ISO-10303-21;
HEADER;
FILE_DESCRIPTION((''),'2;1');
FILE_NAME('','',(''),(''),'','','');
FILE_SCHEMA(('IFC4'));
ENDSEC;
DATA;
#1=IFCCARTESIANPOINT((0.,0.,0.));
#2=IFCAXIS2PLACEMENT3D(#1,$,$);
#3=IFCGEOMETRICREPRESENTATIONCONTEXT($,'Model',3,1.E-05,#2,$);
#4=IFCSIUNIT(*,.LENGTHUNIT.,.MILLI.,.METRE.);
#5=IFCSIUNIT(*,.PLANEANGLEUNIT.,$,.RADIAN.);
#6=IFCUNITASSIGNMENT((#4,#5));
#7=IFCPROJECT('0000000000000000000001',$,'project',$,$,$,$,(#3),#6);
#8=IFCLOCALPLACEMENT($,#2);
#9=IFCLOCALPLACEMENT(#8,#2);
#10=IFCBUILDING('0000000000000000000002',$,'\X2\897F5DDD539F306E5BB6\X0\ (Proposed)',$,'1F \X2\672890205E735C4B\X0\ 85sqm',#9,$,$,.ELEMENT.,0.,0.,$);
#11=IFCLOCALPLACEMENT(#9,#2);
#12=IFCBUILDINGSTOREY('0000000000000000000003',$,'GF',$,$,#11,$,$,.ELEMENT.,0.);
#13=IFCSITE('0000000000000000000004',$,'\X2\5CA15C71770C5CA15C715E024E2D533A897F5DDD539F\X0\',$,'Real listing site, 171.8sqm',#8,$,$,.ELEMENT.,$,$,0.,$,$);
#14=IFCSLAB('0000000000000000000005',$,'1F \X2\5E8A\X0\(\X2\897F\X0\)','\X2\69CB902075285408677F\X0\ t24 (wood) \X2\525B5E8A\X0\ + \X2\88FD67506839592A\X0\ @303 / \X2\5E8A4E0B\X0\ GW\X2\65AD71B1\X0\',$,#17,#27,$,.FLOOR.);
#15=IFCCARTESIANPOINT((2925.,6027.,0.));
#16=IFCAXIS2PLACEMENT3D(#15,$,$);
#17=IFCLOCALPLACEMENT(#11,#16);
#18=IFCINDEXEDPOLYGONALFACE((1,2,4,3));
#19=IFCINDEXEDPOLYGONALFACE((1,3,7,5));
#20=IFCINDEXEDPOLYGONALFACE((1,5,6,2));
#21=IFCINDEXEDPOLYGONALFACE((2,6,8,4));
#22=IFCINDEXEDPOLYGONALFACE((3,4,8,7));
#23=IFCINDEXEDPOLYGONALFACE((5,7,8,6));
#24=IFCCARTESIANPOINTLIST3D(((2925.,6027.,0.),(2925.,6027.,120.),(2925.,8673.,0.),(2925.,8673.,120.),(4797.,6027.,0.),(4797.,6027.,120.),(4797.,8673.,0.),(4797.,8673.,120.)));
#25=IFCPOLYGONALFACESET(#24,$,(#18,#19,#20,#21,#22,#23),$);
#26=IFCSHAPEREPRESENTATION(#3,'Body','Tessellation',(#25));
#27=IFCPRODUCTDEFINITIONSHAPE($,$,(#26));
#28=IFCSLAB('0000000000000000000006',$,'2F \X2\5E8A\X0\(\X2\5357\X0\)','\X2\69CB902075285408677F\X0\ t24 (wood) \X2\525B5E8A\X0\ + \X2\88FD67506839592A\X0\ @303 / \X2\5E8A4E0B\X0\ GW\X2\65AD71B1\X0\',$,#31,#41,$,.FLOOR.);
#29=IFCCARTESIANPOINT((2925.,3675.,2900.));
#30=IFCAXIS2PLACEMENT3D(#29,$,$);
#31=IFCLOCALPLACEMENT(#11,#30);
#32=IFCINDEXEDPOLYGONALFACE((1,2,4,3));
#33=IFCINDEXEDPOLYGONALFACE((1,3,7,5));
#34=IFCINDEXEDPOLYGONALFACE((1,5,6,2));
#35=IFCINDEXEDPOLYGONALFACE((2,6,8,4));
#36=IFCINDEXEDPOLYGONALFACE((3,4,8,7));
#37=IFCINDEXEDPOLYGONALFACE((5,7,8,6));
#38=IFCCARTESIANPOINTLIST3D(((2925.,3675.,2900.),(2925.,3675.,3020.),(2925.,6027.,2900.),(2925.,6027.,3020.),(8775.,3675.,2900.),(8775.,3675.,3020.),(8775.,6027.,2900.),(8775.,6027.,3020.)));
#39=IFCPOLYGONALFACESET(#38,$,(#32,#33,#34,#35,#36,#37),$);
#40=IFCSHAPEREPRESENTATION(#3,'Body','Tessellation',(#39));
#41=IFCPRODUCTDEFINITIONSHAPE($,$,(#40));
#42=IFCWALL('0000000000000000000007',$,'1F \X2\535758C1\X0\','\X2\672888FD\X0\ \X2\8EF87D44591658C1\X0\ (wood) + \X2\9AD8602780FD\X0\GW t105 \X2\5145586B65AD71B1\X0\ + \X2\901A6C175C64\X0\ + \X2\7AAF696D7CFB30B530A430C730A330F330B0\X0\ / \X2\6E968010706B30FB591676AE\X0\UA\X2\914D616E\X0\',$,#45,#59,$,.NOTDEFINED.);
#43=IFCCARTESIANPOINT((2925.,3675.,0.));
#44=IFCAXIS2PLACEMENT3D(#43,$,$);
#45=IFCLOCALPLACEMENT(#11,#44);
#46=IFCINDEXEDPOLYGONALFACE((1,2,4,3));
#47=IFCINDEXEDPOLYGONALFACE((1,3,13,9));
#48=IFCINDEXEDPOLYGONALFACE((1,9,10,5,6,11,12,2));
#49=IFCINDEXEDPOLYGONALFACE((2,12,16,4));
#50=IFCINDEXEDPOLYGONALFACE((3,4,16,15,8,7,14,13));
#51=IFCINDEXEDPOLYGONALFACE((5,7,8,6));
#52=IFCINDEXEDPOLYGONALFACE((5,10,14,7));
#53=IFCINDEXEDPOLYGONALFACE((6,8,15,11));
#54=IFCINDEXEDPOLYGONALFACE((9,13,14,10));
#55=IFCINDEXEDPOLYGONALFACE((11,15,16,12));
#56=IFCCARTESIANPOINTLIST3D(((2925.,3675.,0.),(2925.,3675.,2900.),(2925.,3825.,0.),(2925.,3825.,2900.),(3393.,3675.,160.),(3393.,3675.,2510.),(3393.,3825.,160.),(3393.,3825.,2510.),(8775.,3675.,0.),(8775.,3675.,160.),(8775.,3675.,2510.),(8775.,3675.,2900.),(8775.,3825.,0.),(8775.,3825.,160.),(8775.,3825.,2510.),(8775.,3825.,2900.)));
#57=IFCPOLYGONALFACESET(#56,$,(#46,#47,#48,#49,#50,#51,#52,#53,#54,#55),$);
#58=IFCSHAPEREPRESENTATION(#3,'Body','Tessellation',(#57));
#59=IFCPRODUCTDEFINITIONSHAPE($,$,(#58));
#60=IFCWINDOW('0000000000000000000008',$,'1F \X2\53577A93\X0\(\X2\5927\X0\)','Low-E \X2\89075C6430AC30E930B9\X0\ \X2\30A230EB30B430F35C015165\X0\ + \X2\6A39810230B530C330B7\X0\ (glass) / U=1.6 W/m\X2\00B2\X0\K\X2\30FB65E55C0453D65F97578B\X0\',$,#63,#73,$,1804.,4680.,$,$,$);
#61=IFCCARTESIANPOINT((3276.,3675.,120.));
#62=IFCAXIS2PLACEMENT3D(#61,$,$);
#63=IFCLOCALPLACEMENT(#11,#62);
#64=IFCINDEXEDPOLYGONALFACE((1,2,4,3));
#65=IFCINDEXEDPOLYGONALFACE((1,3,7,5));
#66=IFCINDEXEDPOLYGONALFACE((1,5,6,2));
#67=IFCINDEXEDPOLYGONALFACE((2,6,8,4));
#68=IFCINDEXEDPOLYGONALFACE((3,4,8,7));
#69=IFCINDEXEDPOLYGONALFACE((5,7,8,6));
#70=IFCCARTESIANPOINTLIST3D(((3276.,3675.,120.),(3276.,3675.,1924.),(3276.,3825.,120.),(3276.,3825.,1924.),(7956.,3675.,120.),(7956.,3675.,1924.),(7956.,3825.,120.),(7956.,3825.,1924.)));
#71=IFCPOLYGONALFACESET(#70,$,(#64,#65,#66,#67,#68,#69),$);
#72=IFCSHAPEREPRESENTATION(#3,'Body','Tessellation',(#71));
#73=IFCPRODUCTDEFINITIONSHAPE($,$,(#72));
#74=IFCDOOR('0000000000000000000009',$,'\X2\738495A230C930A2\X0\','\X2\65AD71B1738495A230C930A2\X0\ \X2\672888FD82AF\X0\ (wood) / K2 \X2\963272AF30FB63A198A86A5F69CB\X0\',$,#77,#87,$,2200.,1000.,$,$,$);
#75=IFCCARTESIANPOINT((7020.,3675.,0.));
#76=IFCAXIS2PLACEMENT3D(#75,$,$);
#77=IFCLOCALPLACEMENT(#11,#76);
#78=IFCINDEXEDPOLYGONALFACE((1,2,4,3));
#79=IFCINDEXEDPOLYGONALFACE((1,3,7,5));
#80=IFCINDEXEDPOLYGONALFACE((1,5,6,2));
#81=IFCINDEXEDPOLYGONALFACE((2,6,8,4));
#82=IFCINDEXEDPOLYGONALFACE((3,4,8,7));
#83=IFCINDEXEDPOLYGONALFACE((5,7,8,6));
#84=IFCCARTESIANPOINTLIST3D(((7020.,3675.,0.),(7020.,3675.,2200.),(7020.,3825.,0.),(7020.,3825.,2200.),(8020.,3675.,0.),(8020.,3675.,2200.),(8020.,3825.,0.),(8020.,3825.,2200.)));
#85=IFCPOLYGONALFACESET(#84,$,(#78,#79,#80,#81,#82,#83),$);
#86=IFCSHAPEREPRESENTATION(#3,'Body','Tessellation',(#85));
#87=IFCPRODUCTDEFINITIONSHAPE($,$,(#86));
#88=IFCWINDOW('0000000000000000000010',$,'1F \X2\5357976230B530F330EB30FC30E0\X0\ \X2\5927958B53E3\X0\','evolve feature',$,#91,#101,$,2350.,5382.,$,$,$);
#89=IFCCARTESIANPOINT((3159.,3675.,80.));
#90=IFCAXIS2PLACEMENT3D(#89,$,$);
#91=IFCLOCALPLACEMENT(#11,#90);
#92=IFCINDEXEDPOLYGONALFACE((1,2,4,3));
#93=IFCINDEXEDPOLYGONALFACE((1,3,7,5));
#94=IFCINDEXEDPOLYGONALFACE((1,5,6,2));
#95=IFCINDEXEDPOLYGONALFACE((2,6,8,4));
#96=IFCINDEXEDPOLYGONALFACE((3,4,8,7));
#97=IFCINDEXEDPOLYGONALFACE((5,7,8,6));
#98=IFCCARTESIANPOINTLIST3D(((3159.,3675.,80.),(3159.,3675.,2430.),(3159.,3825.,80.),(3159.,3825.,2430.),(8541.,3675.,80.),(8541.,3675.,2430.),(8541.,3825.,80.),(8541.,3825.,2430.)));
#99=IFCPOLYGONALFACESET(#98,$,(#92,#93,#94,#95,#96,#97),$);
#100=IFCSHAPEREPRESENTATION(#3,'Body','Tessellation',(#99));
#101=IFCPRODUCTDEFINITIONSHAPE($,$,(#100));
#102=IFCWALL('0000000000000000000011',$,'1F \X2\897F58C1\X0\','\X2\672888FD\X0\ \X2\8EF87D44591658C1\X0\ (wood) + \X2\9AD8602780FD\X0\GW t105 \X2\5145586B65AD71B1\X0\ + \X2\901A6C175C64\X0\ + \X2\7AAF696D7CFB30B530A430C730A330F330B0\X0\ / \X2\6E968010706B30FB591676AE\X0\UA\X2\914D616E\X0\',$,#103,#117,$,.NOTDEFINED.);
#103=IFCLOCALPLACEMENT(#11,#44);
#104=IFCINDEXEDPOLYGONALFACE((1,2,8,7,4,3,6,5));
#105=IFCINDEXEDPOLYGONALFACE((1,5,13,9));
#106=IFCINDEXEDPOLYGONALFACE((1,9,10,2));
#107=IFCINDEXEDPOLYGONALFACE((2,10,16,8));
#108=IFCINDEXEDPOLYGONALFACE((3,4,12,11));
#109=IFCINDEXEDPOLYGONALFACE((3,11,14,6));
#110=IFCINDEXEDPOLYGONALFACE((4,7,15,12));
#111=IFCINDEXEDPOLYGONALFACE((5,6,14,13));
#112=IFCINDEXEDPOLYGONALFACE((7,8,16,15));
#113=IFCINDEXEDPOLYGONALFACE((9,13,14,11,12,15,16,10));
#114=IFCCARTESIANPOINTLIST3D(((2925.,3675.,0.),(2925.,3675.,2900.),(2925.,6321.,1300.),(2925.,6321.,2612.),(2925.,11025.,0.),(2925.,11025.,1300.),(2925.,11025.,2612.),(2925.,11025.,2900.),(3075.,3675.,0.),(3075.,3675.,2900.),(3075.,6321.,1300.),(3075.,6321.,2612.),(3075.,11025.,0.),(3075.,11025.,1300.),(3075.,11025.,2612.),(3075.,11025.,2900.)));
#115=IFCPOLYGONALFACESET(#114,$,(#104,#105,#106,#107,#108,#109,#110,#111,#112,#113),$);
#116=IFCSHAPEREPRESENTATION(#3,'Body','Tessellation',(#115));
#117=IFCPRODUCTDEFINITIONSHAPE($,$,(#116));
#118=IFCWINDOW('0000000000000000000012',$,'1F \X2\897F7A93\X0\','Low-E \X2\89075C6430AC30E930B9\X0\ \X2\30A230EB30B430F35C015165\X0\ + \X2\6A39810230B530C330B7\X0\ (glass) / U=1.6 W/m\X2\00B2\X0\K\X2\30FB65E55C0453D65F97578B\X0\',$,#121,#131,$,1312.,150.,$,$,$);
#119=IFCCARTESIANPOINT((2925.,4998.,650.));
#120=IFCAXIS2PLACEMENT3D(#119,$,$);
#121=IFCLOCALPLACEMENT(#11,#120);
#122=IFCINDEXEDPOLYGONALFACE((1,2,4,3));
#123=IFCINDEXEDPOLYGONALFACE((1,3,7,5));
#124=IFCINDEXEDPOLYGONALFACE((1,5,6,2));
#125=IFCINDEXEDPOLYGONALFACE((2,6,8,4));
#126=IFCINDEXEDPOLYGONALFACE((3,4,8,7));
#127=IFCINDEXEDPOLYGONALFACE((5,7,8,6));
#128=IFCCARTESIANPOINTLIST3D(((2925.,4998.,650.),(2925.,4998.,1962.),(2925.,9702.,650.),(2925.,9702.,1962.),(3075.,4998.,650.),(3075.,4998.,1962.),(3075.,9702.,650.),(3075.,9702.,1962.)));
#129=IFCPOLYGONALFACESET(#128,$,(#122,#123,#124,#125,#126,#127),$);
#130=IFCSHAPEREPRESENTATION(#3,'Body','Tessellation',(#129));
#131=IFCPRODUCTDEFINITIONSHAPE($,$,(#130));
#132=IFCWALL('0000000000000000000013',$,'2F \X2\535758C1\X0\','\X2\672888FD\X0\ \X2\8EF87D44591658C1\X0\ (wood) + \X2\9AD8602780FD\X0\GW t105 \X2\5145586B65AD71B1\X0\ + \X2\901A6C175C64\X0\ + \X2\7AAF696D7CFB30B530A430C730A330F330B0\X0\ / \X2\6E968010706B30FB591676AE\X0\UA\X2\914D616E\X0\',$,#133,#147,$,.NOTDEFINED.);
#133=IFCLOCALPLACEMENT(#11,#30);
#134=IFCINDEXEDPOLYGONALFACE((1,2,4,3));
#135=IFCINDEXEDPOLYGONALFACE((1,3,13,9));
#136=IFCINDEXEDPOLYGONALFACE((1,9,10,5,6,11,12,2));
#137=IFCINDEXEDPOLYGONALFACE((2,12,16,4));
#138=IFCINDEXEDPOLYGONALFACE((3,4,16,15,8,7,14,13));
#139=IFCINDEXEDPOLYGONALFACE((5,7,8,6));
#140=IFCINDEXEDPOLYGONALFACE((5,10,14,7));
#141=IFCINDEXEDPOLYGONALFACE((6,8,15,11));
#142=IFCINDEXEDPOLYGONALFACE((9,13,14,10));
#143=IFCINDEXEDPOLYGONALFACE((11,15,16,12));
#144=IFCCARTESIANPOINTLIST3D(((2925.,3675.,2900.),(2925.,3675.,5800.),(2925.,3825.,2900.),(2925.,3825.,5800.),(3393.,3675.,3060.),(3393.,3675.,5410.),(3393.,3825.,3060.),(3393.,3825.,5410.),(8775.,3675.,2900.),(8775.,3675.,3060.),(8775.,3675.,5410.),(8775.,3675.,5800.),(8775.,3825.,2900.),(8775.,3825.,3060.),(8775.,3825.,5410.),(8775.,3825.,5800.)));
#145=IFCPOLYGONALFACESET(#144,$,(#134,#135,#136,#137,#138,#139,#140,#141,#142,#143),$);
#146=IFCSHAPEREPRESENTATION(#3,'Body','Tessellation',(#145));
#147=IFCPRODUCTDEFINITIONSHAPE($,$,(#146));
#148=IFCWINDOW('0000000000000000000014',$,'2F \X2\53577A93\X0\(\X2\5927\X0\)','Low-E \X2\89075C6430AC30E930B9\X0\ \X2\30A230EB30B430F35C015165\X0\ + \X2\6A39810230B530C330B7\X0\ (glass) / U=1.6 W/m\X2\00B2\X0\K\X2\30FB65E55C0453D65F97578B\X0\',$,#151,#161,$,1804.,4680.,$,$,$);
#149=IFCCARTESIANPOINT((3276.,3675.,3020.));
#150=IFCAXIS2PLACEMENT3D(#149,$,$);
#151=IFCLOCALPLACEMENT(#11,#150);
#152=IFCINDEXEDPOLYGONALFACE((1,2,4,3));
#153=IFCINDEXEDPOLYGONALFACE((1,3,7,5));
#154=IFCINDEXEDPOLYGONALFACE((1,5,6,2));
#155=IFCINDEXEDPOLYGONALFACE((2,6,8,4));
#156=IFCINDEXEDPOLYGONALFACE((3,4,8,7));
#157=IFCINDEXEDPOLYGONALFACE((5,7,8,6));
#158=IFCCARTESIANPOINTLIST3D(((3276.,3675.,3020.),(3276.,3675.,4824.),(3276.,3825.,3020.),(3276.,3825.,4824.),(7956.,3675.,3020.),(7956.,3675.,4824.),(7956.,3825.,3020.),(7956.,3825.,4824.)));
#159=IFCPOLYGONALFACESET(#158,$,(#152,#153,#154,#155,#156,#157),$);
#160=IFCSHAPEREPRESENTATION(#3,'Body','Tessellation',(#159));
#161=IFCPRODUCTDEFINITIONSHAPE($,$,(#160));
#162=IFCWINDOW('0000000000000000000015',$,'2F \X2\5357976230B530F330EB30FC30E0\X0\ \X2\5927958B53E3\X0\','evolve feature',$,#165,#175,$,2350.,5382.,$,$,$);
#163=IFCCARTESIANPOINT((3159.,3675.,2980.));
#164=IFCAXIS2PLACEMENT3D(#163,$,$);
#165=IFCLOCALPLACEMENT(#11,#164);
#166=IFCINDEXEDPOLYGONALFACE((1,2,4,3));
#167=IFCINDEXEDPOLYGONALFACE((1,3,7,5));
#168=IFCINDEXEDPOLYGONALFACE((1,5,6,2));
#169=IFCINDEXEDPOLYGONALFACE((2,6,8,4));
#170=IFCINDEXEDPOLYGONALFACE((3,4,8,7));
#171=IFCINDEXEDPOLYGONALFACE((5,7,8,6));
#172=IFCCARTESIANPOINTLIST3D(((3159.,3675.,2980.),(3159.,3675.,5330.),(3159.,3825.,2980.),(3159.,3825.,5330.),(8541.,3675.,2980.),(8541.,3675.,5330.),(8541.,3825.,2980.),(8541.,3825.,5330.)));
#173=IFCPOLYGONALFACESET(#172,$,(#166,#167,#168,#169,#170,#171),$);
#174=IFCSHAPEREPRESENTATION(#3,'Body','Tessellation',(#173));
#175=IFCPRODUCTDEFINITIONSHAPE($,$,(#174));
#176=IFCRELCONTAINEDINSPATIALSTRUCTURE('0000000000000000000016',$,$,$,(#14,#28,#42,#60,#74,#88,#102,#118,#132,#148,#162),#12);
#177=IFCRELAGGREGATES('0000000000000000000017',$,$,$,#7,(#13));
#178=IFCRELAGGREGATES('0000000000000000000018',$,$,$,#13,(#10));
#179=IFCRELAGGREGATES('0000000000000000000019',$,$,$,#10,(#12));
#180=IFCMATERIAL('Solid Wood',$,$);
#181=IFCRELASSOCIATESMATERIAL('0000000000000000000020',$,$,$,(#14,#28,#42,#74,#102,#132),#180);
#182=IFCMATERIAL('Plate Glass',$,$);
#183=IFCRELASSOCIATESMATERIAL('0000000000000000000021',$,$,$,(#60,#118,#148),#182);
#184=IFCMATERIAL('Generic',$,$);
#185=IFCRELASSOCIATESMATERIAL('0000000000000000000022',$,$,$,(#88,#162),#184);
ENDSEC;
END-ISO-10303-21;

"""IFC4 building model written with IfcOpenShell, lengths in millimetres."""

from ifc_helpers import new_model, si_unit, frame, frame_2d, origin, place, context, project, spatial, rectangle, extrude, material, element, fill, save


model = new_model("IFC4")

# Units and contexts
model_context = context("Model", 3, precision=1e-05, world=origin())
ifc_project = project(units=[si_unit("LENGTHUNIT", "METRE", prefix="MILLI"), si_unit("PLANEANGLEUNIT", "RADIAN")], contexts=[model_context])

# Site, building, storey
site_placement = place(None, origin())
site = spatial("IfcSite", under=ifc_project, at=site_placement, Name="岡山県岡山市中区西川原", ObjectType="Real listing site, 171.8sqm", CompositionType="ELEMENT", RefElevation=0.0)
building_placement = place(site_placement, origin())
building = spatial("IfcBuilding", under=site, at=building_placement, Name="西川原の家 (Proposed)", ObjectType="1F 木造平屋 85sqm", CompositionType="ELEMENT", ElevationOfRefHeight=0.0, ElevationOfTerrain=0.0)
storey_placement = place(building_placement, origin())
storey = spatial("IfcBuildingStorey", under=building, at=storey_placement, Name="GF", CompositionType="ELEMENT", Elevation=0.0)

# Slabs
ifc_material_1 = material(Name="Solid Wood")
slab_1_placement = place(storey_placement, frame((2925.0, 6027.0, 0.0)))
element("IfcSlab", 1, at=slab_1_placement, inside=storey, material=ifc_material_1, Name="1F 床(西)", Description="構造用合板 t24 (wood) 剛床 + 製材根太 @303 / 床下 GW断熱", PredefinedType="FLOOR", context=model_context, shape_type="SweptSolid", body=[
    extrude(rectangle(XDim=1872.0, YDim=2646.0, at=frame_2d((936.0, 1323.0))), frame((2925.0, 6027.0, 0.0)), (0.0, 0.0, 1.0), 120.0),
])
slab_2_placement = place(storey_placement, frame((2925.0, 3675.0, 2900.0)))
element("IfcSlab", 2, at=slab_2_placement, inside=storey, material=ifc_material_1, Name="2F 床(南)", Description="構造用合板 t24 (wood) 剛床 + 製材根太 @303 / 床下 GW断熱", PredefinedType="FLOOR", context=model_context, shape_type="SweptSolid", body=[
    extrude(rectangle(XDim=5850.0, YDim=2352.0, at=frame_2d((2925.0, 1176.0))), frame((2925.0, 3675.0, 2900.0)), (0.0, 0.0, 1.0), 120.0),
])
ifc_material_2 = material(Name="Generic")

# Wall, openings, windows, door
wall_1_placement = place(storey_placement, frame((2925.0, 3675.0, 0.0)))
wall_1 = element("IfcWall", 3, at=wall_1_placement, inside=storey, material=ifc_material_1, Name="1F 南壁", Description="木製 軸組外壁 (wood) + 高性能GW t105 充填断熱 + 通気層 + 窯業系サイディング / 準耐火・外皮UA配慮", PredefinedType="NOTDEFINED", context=model_context, shape_type="SweptSolid", body=[
    extrude(rectangle(XDim=5850.0, YDim=150.0, at=frame_2d((2925.0, 75.0))), frame((2925.0, 3675.0, 0.0)), (0.0, 0.0, 1.0), 2900.0),
])
opening_1_placement = place(storey_placement, frame((3276.0, 3675.0, 120.0)))
opening_1 = element("IfcOpeningElement", 4, at=opening_1_placement, cuts=wall_1, PredefinedType="NOTDEFINED", context=model_context, shape_type="SweptSolid", body=[
    extrude(rectangle(XDim=4680.0, YDim=150.0, at=frame_2d((2340.0, 75.0))), frame((3276.0, 3675.0, 120.0)), (0.0, 0.0, 1.0), 1804.0),
])
opening_2_placement = place(storey_placement, frame((7020.0, 3675.0, 0.0)))
opening_2 = element("IfcOpeningElement", 5, at=opening_2_placement, cuts=wall_1, PredefinedType="NOTDEFINED", context=model_context, shape_type="SweptSolid", body=[
    extrude(rectangle(XDim=1000.0, YDim=150.0, at=frame_2d((500.0, 75.0))), frame((7020.0, 3675.0, 0.0)), (0.0, 0.0, 1.0), 2200.0),
])
opening_3_placement = place(storey_placement, frame((3159.0, 3675.0, 80.0)))
opening_3 = element("IfcOpeningElement", 6, at=opening_3_placement, cuts=wall_1, PredefinedType="NOTDEFINED", context=model_context, shape_type="SweptSolid", body=[
    extrude(rectangle(XDim=5382.0, YDim=150.0, at=frame_2d((2691.0, 75.0))), frame((3159.0, 3675.0, 80.0)), (0.0, 0.0, 1.0), 2350.0),
])
ifc_material_3 = material(Name="Plate Glass")
window_1_placement = place(storey_placement, frame((3276.0, 3675.0, 120.0)))
window_1 = element("IfcWindow", 7, at=window_1_placement, inside=storey, material=ifc_material_3, Name="1F 南窓(大)", Description="Low-E 複層ガラス アルゴン封入 + 樹脂サッシ (glass) / U=1.6 W/m²K・日射取得型", OverallHeight=1804.0, OverallWidth=4680.0, context=model_context, shape_type="SweptSolid", body=[
    extrude(rectangle(XDim=4680.0, YDim=150.0, at=frame_2d((2340.0, 75.0))), frame((3276.0, 3675.0, 120.0)), (0.0, 0.0, 1.0), 1804.0),
])
fill(opening_1, window_1)
door_placement = place(storey_placement, frame((7020.0, 3675.0, 0.0)))
door = element("IfcDoor", 8, at=door_placement, inside=storey, material=ifc_material_1, Name="玄関ドア", Description="断熱玄関ドア 木製芯 (wood) / K2 防犯・採風機構", OverallHeight=2200.0, OverallWidth=1000.0, context=model_context, shape_type="SweptSolid", body=[
    extrude(rectangle(XDim=1000.0, YDim=150.0, at=frame_2d((500.0, 75.0))), frame((7020.0, 3675.0, 0.0)), (0.0, 0.0, 1.0), 2200.0),
])
fill(opening_2, door)
window_2_placement = place(storey_placement, frame((3159.0, 3675.0, 80.0)))
window_2 = element("IfcWindow", 9, at=window_2_placement, inside=storey, material=ifc_material_2, Name="1F 南面サンルーム 大開口", Description="evolve feature", OverallHeight=2350.0, OverallWidth=5382.0, context=model_context, shape_type="SweptSolid", body=[
    extrude(rectangle(XDim=5382.0, YDim=150.0, at=frame_2d((2691.0, 75.0))), frame((3159.0, 3675.0, 80.0)), (0.0, 0.0, 1.0), 2350.0),
])
fill(opening_3, window_2)

# Wall, opening, window
wall_2_placement = place(storey_placement, frame((2925.0, 3675.0, 0.0)))
wall_2 = element("IfcWall", 10, at=wall_2_placement, inside=storey, material=ifc_material_1, Name="1F 西壁", Description="木製 軸組外壁 (wood) + 高性能GW t105 充填断熱 + 通気層 + 窯業系サイディング / 準耐火・外皮UA配慮", PredefinedType="NOTDEFINED", context=model_context, shape_type="SweptSolid", body=[
    extrude(rectangle(XDim=150.0, YDim=7350.0, at=frame_2d((75.0, 3675.0))), frame((2925.0, 3675.0, 0.0)), (0.0, 0.0, 1.0), 2900.0),
])
opening_4_placement = place(storey_placement, frame((2925.0, 4998.0, 650.0)))
opening_4 = element("IfcOpeningElement", 11, at=opening_4_placement, cuts=wall_2, PredefinedType="NOTDEFINED", context=model_context, shape_type="SweptSolid", body=[
    extrude(rectangle(XDim=150.0, YDim=4704.0, at=frame_2d((75.0, 2352.0))), frame((2925.0, 4998.0, 650.0)), (0.0, 0.0, 1.0), 1312.0),
])
window_3_placement = place(storey_placement, frame((2925.0, 4998.0, 650.0)))
window_3 = element("IfcWindow", 12, at=window_3_placement, inside=storey, material=ifc_material_3, Name="1F 西窓", Description="Low-E 複層ガラス アルゴン封入 + 樹脂サッシ (glass) / U=1.6 W/m²K・日射取得型", OverallHeight=1312.0, OverallWidth=150.0, context=model_context, shape_type="SweptSolid", body=[
    extrude(rectangle(XDim=150.0, YDim=4704.0, at=frame_2d((75.0, 2352.0))), frame((2925.0, 4998.0, 650.0)), (0.0, 0.0, 1.0), 1312.0),
])
fill(opening_4, window_3)

# Wall, openings, windows
wall_3_placement = place(storey_placement, frame((2925.0, 3675.0, 2900.0)))
wall_3 = element("IfcWall", 13, at=wall_3_placement, inside=storey, material=ifc_material_1, Name="2F 南壁", Description="木製 軸組外壁 (wood) + 高性能GW t105 充填断熱 + 通気層 + 窯業系サイディング / 準耐火・外皮UA配慮", PredefinedType="NOTDEFINED", context=model_context, shape_type="SweptSolid", body=[
    extrude(rectangle(XDim=5850.0, YDim=150.0, at=frame_2d((2925.0, 75.0))), frame((2925.0, 3675.0, 2900.0)), (0.0, 0.0, 1.0), 2900.0),
])
opening_5_placement = place(storey_placement, frame((3276.0, 3675.0, 3020.0)))
opening_5 = element("IfcOpeningElement", 14, at=opening_5_placement, cuts=wall_3, PredefinedType="NOTDEFINED", context=model_context, shape_type="SweptSolid", body=[
    extrude(rectangle(XDim=4680.0, YDim=150.0, at=frame_2d((2340.0, 75.0))), frame((3276.0, 3675.0, 3020.0)), (0.0, 0.0, 1.0), 1804.0),
])
opening_6_placement = place(storey_placement, frame((3159.0, 3675.0, 2980.0)))
opening_6 = element("IfcOpeningElement", 15, at=opening_6_placement, cuts=wall_3, PredefinedType="NOTDEFINED", context=model_context, shape_type="SweptSolid", body=[
    extrude(rectangle(XDim=5382.0, YDim=150.0, at=frame_2d((2691.0, 75.0))), frame((3159.0, 3675.0, 2980.0)), (0.0, 0.0, 1.0), 2350.0),
])
window_4_placement = place(storey_placement, frame((3276.0, 3675.0, 3020.0)))
window_4 = element("IfcWindow", 16, at=window_4_placement, inside=storey, material=ifc_material_3, Name="2F 南窓(大)", Description="Low-E 複層ガラス アルゴン封入 + 樹脂サッシ (glass) / U=1.6 W/m²K・日射取得型", OverallHeight=1804.0, OverallWidth=4680.0, context=model_context, shape_type="SweptSolid", body=[
    extrude(rectangle(XDim=4680.0, YDim=150.0, at=frame_2d((2340.0, 75.0))), frame((3276.0, 3675.0, 3020.0)), (0.0, 0.0, 1.0), 1804.0),
])
fill(opening_5, window_4)
window_5_placement = place(storey_placement, frame((3159.0, 3675.0, 2980.0)))
window_5 = element("IfcWindow", 17, at=window_5_placement, inside=storey, material=ifc_material_2, Name="2F 南面サンルーム 大開口", Description="evolve feature", OverallHeight=2350.0, OverallWidth=5382.0, context=model_context, shape_type="SweptSolid", body=[
    extrude(rectangle(XDim=5382.0, YDim=150.0, at=frame_2d((2691.0, 75.0))), frame((3159.0, 3675.0, 2980.0)), (0.0, 0.0, 1.0), 2350.0),
])
fill(opening_6, window_5)

save(model, "model.ifc")
